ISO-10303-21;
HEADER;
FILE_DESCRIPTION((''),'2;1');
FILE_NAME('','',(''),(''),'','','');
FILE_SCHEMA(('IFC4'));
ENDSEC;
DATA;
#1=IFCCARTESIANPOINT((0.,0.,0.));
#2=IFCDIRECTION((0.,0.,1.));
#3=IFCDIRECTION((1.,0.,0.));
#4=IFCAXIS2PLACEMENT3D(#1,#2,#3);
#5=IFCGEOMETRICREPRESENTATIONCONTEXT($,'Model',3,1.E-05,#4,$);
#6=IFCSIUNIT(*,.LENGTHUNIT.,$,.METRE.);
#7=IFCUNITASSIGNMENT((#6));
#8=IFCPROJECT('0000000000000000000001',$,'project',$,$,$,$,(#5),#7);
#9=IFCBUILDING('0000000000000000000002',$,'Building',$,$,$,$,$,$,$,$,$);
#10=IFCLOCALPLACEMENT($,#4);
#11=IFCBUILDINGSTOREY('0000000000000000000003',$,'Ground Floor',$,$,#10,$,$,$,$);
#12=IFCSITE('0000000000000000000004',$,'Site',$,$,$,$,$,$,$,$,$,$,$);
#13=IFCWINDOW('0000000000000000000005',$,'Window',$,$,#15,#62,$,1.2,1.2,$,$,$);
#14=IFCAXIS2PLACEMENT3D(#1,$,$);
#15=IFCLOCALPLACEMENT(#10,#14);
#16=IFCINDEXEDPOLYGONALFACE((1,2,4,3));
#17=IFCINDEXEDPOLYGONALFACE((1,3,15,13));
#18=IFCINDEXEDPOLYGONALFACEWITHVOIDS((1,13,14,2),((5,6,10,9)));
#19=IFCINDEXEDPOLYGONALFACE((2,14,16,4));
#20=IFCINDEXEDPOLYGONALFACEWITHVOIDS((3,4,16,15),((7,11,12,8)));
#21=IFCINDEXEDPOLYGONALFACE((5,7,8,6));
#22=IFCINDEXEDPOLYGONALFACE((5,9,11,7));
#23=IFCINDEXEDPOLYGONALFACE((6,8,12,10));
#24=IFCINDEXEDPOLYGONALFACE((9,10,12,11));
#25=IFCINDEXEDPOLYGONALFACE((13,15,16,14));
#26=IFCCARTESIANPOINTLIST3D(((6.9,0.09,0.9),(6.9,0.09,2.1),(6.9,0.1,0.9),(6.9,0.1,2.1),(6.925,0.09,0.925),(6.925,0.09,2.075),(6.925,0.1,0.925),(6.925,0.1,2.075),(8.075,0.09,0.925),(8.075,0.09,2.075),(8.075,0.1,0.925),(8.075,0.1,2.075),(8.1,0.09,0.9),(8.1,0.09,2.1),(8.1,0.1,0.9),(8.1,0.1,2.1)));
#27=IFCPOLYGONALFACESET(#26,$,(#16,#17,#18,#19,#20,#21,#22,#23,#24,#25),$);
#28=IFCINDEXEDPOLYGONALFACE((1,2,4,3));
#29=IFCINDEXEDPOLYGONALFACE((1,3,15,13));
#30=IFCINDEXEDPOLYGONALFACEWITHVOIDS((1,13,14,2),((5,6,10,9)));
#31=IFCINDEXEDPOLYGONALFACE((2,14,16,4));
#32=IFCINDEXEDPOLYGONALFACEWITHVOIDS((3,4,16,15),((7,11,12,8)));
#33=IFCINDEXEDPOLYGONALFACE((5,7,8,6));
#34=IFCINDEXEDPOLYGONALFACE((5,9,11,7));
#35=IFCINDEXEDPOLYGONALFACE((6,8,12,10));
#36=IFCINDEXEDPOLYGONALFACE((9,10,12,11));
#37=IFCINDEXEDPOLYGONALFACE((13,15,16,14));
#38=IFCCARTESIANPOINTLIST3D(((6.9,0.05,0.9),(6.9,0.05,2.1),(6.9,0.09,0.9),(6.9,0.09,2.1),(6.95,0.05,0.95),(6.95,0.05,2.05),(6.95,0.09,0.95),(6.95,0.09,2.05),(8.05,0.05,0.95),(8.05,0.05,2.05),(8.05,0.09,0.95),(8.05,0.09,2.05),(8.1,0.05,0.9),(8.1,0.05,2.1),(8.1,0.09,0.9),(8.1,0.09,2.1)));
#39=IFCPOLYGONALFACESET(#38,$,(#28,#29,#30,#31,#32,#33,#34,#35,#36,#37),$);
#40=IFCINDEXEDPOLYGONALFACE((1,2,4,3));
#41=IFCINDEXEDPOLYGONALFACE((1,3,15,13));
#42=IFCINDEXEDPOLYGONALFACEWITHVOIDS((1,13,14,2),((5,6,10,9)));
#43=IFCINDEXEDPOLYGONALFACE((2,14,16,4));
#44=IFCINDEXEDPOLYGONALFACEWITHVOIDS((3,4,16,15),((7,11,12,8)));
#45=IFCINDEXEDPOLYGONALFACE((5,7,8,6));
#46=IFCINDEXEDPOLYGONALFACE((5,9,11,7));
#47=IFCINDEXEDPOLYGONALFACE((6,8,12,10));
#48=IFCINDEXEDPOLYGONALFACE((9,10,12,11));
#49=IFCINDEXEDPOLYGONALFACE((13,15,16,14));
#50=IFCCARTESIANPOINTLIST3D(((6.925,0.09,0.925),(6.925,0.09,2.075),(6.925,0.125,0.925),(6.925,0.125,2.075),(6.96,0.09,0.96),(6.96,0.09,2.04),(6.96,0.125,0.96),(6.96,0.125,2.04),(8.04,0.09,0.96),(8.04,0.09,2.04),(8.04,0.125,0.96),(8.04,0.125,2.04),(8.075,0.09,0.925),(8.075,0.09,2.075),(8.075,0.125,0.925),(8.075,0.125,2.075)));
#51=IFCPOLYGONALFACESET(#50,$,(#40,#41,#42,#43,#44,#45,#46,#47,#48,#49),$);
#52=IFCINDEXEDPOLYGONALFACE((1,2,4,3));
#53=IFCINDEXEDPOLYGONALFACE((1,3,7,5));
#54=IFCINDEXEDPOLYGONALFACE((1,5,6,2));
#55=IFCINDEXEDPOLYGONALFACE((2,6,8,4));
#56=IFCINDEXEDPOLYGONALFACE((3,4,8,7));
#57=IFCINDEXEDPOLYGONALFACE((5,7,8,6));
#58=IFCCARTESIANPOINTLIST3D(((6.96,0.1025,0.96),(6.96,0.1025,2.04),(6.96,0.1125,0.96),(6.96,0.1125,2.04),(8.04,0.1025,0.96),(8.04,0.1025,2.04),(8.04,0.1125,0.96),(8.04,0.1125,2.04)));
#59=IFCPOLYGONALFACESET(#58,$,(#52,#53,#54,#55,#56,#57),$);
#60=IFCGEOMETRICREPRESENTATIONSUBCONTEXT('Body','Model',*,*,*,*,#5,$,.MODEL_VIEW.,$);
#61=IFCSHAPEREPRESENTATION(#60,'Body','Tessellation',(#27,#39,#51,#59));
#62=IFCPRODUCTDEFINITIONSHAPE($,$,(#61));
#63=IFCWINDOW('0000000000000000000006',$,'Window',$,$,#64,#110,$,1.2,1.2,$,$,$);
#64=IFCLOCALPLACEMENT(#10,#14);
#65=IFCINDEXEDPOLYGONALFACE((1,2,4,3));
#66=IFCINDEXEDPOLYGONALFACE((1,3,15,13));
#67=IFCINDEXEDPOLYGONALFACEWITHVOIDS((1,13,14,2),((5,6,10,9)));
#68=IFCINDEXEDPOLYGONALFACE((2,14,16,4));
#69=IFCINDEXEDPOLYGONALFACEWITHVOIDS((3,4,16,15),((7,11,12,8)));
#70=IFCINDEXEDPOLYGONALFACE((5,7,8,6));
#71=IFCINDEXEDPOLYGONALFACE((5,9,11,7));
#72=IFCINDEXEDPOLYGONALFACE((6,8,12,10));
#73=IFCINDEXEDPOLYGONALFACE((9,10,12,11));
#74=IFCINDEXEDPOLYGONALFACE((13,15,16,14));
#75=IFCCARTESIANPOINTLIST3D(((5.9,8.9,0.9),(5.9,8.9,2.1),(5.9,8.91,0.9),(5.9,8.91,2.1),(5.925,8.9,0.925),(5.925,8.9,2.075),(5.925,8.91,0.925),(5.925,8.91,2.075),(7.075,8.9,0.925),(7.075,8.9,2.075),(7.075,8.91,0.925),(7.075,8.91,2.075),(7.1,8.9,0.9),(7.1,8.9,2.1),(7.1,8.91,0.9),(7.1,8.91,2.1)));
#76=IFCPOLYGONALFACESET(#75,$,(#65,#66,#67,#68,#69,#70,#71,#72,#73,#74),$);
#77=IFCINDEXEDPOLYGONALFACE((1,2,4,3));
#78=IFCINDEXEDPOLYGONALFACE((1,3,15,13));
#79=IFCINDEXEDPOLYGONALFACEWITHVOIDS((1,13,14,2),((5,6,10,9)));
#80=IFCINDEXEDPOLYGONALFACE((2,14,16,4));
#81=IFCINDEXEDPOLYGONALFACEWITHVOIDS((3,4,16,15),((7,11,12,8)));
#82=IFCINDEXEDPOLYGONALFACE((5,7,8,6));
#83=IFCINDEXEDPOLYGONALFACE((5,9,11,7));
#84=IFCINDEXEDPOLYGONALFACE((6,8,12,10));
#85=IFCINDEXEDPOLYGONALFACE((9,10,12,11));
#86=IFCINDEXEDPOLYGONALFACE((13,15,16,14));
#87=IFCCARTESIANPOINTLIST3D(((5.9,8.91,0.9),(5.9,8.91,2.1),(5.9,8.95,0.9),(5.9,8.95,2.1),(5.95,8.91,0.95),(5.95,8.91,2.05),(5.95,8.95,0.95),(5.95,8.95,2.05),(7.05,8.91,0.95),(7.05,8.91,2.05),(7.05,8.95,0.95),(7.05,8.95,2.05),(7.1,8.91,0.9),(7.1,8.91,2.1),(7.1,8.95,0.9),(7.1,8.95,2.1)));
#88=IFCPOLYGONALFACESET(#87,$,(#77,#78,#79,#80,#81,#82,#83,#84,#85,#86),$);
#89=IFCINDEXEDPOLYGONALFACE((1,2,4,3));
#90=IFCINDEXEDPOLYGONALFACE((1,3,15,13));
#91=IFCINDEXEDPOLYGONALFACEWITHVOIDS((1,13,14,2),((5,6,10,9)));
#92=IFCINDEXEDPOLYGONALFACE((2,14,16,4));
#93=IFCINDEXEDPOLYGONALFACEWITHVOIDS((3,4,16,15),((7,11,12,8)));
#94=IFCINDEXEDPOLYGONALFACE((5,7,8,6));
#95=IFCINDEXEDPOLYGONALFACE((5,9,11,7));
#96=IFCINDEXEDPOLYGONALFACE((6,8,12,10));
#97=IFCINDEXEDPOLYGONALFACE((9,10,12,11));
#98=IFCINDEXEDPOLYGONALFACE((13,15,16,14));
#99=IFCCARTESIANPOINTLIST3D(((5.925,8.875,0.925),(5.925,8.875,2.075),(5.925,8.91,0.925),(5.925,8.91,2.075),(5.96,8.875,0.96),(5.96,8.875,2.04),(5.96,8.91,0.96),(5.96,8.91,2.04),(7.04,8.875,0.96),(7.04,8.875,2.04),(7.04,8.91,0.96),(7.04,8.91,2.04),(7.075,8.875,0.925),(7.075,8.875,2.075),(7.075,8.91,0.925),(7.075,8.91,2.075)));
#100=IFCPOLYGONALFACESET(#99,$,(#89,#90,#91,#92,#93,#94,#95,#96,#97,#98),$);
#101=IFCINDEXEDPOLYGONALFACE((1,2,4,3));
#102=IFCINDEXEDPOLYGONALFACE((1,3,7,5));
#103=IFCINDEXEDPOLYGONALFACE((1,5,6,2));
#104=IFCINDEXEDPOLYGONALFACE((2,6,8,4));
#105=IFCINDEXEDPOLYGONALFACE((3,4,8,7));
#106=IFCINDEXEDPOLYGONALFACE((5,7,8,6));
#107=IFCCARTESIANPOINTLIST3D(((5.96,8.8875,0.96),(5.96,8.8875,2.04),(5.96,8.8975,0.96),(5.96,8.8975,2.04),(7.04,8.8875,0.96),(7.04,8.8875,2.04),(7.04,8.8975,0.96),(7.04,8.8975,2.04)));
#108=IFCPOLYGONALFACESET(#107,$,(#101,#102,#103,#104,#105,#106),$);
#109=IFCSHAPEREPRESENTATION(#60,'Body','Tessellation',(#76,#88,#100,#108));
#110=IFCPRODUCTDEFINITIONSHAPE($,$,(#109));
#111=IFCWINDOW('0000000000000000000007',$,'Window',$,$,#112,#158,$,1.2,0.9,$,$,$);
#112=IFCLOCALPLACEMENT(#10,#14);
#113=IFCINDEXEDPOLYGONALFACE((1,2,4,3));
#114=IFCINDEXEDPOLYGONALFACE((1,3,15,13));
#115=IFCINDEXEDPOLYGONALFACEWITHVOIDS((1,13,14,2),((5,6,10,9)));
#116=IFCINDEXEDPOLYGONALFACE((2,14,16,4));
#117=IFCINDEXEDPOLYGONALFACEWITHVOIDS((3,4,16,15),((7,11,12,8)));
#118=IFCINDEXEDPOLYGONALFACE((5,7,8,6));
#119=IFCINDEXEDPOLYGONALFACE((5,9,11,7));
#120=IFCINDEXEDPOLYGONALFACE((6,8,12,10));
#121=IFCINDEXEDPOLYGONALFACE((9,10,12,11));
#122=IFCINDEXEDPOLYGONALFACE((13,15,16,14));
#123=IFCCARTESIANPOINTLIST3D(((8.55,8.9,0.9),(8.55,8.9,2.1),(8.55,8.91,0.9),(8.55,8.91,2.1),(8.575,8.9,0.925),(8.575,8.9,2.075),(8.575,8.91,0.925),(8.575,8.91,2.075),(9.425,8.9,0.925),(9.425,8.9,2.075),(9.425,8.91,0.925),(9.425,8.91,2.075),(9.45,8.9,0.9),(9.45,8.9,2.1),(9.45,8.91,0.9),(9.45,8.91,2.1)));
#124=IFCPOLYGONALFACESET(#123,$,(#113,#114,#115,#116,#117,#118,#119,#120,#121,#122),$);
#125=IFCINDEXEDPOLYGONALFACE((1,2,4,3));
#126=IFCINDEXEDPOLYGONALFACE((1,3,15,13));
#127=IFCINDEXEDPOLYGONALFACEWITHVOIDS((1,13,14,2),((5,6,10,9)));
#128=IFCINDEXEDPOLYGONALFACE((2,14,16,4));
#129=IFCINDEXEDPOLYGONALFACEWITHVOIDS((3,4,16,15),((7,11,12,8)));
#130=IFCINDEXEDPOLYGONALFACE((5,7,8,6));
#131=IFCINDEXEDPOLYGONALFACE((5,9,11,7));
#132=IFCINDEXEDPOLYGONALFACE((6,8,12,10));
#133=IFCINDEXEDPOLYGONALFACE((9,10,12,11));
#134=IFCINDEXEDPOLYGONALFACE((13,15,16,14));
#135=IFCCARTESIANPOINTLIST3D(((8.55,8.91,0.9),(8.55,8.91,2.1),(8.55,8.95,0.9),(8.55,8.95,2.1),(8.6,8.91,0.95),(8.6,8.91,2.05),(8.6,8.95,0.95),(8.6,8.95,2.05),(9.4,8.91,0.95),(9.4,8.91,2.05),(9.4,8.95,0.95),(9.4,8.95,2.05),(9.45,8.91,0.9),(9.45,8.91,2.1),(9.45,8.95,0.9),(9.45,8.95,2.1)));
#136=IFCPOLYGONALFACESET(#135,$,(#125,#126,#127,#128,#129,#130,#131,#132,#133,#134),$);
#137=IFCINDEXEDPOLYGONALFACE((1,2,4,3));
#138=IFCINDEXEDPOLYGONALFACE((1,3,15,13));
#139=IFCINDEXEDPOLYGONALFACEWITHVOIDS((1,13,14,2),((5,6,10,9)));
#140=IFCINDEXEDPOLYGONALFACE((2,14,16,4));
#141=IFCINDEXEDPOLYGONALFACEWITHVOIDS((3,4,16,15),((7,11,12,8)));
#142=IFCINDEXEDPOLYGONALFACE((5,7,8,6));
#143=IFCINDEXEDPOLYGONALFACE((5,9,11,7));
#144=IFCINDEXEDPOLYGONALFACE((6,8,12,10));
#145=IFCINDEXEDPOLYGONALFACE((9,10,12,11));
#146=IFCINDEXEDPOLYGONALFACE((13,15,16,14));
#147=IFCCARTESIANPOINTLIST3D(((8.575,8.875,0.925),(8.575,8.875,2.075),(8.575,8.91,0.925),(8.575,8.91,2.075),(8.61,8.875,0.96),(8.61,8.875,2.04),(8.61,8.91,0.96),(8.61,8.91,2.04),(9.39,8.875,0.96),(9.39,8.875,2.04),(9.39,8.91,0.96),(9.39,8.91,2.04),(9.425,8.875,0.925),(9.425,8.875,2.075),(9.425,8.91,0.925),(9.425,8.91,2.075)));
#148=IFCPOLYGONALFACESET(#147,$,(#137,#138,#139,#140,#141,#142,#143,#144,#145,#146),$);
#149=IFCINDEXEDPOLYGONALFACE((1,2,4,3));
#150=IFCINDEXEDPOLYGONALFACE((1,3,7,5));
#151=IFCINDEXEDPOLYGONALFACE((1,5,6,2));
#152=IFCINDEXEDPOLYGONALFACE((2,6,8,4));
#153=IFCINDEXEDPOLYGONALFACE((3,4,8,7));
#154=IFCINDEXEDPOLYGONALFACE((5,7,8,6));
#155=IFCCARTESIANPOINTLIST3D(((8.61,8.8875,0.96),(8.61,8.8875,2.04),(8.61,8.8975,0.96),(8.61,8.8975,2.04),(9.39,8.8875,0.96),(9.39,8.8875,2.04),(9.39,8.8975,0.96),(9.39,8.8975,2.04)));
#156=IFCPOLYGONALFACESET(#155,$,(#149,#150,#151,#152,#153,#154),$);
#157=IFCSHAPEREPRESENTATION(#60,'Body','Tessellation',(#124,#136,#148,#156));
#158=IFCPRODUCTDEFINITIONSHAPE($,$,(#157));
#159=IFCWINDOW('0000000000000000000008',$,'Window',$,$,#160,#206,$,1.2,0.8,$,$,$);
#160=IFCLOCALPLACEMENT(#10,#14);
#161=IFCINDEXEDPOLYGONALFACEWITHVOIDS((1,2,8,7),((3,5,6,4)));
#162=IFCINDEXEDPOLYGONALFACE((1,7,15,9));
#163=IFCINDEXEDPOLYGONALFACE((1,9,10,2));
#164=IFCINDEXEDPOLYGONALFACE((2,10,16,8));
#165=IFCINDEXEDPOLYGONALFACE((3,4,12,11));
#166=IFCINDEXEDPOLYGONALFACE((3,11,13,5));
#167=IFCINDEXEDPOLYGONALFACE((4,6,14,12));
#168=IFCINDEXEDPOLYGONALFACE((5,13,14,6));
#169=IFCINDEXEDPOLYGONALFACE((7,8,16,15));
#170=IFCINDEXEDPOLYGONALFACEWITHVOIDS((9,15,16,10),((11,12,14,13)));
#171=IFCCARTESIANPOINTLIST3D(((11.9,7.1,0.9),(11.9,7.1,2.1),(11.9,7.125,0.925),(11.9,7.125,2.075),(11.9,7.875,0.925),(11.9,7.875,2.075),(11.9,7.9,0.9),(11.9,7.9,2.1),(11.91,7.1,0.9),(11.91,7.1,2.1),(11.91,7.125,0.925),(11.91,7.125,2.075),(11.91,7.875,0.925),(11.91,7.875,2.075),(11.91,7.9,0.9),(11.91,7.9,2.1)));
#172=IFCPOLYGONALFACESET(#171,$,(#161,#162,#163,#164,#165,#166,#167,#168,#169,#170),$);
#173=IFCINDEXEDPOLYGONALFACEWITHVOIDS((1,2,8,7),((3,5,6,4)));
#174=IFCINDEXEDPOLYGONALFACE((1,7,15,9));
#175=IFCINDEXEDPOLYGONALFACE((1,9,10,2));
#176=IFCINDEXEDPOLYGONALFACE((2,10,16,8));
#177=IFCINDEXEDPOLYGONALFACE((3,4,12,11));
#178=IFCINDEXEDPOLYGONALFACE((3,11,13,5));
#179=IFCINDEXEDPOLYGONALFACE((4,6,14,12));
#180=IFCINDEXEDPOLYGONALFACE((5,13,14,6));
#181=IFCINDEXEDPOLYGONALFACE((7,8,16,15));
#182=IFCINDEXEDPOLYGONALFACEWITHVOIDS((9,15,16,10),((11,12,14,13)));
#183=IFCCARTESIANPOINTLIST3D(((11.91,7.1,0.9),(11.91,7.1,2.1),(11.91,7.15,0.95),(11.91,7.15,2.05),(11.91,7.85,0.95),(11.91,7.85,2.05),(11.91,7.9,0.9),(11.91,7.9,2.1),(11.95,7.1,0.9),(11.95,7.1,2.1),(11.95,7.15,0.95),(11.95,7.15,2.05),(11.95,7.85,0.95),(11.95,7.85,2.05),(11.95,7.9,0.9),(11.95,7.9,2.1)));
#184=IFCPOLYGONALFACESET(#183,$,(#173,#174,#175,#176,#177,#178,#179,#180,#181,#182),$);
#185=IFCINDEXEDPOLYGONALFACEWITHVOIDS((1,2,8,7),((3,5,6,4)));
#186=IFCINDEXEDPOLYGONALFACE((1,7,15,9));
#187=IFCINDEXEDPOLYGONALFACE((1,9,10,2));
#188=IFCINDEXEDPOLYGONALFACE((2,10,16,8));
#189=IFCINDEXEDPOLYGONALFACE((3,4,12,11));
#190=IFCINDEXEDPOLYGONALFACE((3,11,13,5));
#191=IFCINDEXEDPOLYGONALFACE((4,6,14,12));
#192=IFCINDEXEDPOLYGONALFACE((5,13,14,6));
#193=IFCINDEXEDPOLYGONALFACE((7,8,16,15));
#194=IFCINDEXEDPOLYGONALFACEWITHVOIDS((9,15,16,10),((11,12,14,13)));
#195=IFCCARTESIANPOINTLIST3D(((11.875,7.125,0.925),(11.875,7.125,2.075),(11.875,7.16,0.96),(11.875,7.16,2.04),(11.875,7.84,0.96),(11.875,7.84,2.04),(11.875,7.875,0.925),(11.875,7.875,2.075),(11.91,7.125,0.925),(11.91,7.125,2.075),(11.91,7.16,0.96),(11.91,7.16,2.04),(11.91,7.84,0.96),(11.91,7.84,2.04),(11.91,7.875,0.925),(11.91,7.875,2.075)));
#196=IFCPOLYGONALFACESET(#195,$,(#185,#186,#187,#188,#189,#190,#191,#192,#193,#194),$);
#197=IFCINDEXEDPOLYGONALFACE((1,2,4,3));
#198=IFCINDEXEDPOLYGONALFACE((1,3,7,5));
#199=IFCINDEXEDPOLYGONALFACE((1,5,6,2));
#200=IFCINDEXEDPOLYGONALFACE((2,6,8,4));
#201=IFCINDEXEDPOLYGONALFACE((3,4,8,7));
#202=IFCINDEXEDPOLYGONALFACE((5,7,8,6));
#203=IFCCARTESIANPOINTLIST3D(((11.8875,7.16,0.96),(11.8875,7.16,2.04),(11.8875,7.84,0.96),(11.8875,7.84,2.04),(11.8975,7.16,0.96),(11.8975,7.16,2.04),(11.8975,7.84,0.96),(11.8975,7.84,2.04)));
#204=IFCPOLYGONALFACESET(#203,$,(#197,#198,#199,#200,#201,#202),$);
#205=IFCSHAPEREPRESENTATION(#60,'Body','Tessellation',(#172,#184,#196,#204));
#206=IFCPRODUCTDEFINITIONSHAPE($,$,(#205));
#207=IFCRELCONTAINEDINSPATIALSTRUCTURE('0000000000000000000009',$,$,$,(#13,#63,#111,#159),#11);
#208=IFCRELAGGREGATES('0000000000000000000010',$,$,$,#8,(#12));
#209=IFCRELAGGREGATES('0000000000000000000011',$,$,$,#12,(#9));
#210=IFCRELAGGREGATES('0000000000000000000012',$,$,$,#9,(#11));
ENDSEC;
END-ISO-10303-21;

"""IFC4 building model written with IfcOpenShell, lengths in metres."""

from ifc_helpers import new_model, si_unit, frame, origin_with_axes, place, context, subcontext, project, spatial, line, indexed_curve, outline, extrude, element, save


model = new_model("IFC4")

# Units and contexts
model_context = context("Model", 3, precision=1e-05, world=origin_with_axes())
body_context = subcontext(model_context, "Body", "Model", "MODEL_VIEW")
ifc_project = project(units=[si_unit("LENGTHUNIT", "METRE")], contexts=[model_context])

# Site, building, storey
site = spatial("IfcSite", under=ifc_project, Name="Site")
building = spatial("IfcBuilding", under=site, Name="Building")
storey_placement = place(None, origin_with_axes())
storey = spatial("IfcBuildingStorey", under=building, at=storey_placement, Name="Ground Floor")

# Windows
for number, where, z_axis, x_axis, name in (
    (1, (6.9, 0.0, 0.9), (0.0, 0.0, 1.0), (1.0, 0.0, 0.0), "Window"),
    (2, (7.1, 9.0, 0.9), (0.0, 0.0, 1.0), (-1.0, 0.0, 0.0), "Window"),
):
    element("IfcWindow", number, at=place(storey_placement, frame(where, z_axis=z_axis, x_axis=x_axis)), inside=storey, Name=name, OverallHeight=1.2, OverallWidth=1.2, context=body_context, shape_type="SweptSolid", body=[
        extrude(outline(indexed_curve([(0.0, 0.0), (1.2, 0.0), (1.2, 1.2), (0.0, 1.2)], segments=[line(1, 2, 3, 4, 1)]), holes=[indexed_curve([(0.025, 0.025), (1.175, 0.025), (1.175, 1.175), (0.025, 1.175)], segments=[line(1, 2, 3, 4, 1)])]), frame((0.0, 0.09, 0.0), z_axis=(0.0, -1.0, 0.0), x_axis=(1.0, 0.0, 0.0)), (0.0, 0.0, -1.0), 0.01),
        extrude(outline(indexed_curve([(0.0, 0.0), (1.2, 0.0), (1.2, 1.2), (0.0, 1.2)], segments=[line(1, 2, 3, 4, 1)]), holes=[indexed_curve([(0.05, 0.05), (1.15, 0.05), (1.15, 1.15), (0.05, 1.15)], segments=[line(1, 2, 3, 4, 1)])]), frame((0.0, 0.05, 0.0), z_axis=(0.0, -1.0, 0.0), x_axis=(1.0, 0.0, 0.0)), (0.0, 0.0, -1.0), 0.04),
        extrude(outline(indexed_curve([(0.0, 0.0), (1.15, 0.0), (1.15, 1.15), (0.0, 1.15)], segments=[line(1, 2, 3, 4, 1)]), holes=[indexed_curve([(0.035, 0.035), (1.115, 0.035), (1.115, 1.115), (0.035, 1.115)], segments=[line(1, 2, 3, 4, 1)])]), frame((0.025, 0.09, 0.025), z_axis=(0.0, -1.0, 0.0), x_axis=(1.0, 0.0, 0.0)), (0.0, 0.0, -1.0), 0.035),
        extrude(outline(indexed_curve([(0.035, 0.035), (1.115, 0.035), (1.115, 1.115), (0.035, 1.115)], segments=[line(1, 2, 3, 4, 1)])), frame((0.025, 0.1025, 0.025), z_axis=(0.0, -1.0, 0.0), x_axis=(1.0, 0.0, 0.0)), (0.0, 0.0, -1.0), 0.01),
    ])
window_1_placement = place(storey_placement, frame((9.45, 9.0, 0.9), z_axis=(0.0, 0.0, 1.0), x_axis=(-1.0, 0.0, 0.0)))
element("IfcWindow", 3, at=window_1_placement, inside=storey, Name="Window", OverallHeight=1.2, OverallWidth=0.9, context=body_context, shape_type="SweptSolid", body=[
    extrude(outline(indexed_curve([(0.0, 0.0), (0.9, 0.0), (0.9, 1.2), (0.0, 1.2)], segments=[line(1, 2, 3, 4, 1)]), holes=[indexed_curve([(0.025, 0.025), (0.875, 0.025), (0.875, 1.175), (0.025, 1.175)], segments=[line(1, 2, 3, 4, 1)])]), frame((0.0, 0.09, 0.0), z_axis=(0.0, -1.0, 0.0), x_axis=(1.0, 0.0, 0.0)), (0.0, 0.0, -1.0), 0.01),
    extrude(outline(indexed_curve([(0.0, 0.0), (0.9, 0.0), (0.9, 1.2), (0.0, 1.2)], segments=[line(1, 2, 3, 4, 1)]), holes=[indexed_curve([(0.05, 0.05), (0.85, 0.05), (0.85, 1.15), (0.05, 1.15)], segments=[line(1, 2, 3, 4, 1)])]), frame((0.0, 0.05, 0.0), z_axis=(0.0, -1.0, 0.0), x_axis=(1.0, 0.0, 0.0)), (0.0, 0.0, -1.0), 0.04),
    extrude(outline(indexed_curve([(0.0, 0.0), (0.85, 0.0), (0.85, 1.15), (0.0, 1.15)], segments=[line(1, 2, 3, 4, 1)]), holes=[indexed_curve([(0.035, 0.035), (0.815, 0.035), (0.815, 1.115), (0.035, 1.115)], segments=[line(1, 2, 3, 4, 1)])]), frame((0.025, 0.09, 0.025), z_axis=(0.0, -1.0, 0.0), x_axis=(1.0, 0.0, 0.0)), (0.0, 0.0, -1.0), 0.035),
    extrude(outline(indexed_curve([(0.035, 0.035), (0.815, 0.035), (0.815, 1.115), (0.035, 1.115)], segments=[line(1, 2, 3, 4, 1)])), frame((0.025, 0.1025, 0.025), z_axis=(0.0, -1.0, 0.0), x_axis=(1.0, 0.0, 0.0)), (0.0, 0.0, -1.0), 0.01),
])
window_2_placement = place(storey_placement, frame((12.0, 7.1, 0.9), z_axis=(0.0, 0.0, 1.0), x_axis=(0.0, 1.0, 0.0)))
element("IfcWindow", 4, at=window_2_placement, inside=storey, Name="Window", OverallHeight=1.2, OverallWidth=0.8, context=body_context, shape_type="SweptSolid", body=[
    extrude(outline(indexed_curve([(0.0, 0.0), (0.8, 0.0), (0.8, 1.2), (0.0, 1.2)], segments=[line(1, 2, 3, 4, 1)]), holes=[indexed_curve([(0.025, 0.025), (0.775, 0.025), (0.775, 1.175), (0.025, 1.175)], segments=[line(1, 2, 3, 4, 1)])]), frame((0.0, 0.09, 0.0), z_axis=(0.0, -1.0, 0.0), x_axis=(1.0, 0.0, 0.0)), (0.0, 0.0, -1.0), 0.01),
    extrude(outline(indexed_curve([(0.0, 0.0), (0.8, 0.0), (0.8, 1.2), (0.0, 1.2)], segments=[line(1, 2, 3, 4, 1)]), holes=[indexed_curve([(0.05, 0.05), (0.75, 0.05), (0.75, 1.15), (0.05, 1.15)], segments=[line(1, 2, 3, 4, 1)])]), frame((0.0, 0.05, 0.0), z_axis=(0.0, -1.0, 0.0), x_axis=(1.0, 0.0, 0.0)), (0.0, 0.0, -1.0), 0.04),
    extrude(outline(indexed_curve([(0.0, 0.0), (0.75, 0.0), (0.75, 1.15), (0.0, 1.15)], segments=[line(1, 2, 3, 4, 1)]), holes=[indexed_curve([(0.035, 0.035), (0.715, 0.035), (0.715, 1.115), (0.035, 1.115)], segments=[line(1, 2, 3, 4, 1)])]), frame((0.025, 0.09, 0.025), z_axis=(0.0, -1.0, 0.0), x_axis=(1.0, 0.0, 0.0)), (0.0, 0.0, -1.0), 0.035),
    extrude(outline(indexed_curve([(0.035, 0.035), (0.715, 0.035), (0.715, 1.115), (0.035, 1.115)], segments=[line(1, 2, 3, 4, 1)])), frame((0.025, 0.1025, 0.025), z_axis=(0.0, -1.0, 0.0), x_axis=(1.0, 0.0, 0.0)), (0.0, 0.0, -1.0), 0.01),
])

save(model, "model.ifc")
